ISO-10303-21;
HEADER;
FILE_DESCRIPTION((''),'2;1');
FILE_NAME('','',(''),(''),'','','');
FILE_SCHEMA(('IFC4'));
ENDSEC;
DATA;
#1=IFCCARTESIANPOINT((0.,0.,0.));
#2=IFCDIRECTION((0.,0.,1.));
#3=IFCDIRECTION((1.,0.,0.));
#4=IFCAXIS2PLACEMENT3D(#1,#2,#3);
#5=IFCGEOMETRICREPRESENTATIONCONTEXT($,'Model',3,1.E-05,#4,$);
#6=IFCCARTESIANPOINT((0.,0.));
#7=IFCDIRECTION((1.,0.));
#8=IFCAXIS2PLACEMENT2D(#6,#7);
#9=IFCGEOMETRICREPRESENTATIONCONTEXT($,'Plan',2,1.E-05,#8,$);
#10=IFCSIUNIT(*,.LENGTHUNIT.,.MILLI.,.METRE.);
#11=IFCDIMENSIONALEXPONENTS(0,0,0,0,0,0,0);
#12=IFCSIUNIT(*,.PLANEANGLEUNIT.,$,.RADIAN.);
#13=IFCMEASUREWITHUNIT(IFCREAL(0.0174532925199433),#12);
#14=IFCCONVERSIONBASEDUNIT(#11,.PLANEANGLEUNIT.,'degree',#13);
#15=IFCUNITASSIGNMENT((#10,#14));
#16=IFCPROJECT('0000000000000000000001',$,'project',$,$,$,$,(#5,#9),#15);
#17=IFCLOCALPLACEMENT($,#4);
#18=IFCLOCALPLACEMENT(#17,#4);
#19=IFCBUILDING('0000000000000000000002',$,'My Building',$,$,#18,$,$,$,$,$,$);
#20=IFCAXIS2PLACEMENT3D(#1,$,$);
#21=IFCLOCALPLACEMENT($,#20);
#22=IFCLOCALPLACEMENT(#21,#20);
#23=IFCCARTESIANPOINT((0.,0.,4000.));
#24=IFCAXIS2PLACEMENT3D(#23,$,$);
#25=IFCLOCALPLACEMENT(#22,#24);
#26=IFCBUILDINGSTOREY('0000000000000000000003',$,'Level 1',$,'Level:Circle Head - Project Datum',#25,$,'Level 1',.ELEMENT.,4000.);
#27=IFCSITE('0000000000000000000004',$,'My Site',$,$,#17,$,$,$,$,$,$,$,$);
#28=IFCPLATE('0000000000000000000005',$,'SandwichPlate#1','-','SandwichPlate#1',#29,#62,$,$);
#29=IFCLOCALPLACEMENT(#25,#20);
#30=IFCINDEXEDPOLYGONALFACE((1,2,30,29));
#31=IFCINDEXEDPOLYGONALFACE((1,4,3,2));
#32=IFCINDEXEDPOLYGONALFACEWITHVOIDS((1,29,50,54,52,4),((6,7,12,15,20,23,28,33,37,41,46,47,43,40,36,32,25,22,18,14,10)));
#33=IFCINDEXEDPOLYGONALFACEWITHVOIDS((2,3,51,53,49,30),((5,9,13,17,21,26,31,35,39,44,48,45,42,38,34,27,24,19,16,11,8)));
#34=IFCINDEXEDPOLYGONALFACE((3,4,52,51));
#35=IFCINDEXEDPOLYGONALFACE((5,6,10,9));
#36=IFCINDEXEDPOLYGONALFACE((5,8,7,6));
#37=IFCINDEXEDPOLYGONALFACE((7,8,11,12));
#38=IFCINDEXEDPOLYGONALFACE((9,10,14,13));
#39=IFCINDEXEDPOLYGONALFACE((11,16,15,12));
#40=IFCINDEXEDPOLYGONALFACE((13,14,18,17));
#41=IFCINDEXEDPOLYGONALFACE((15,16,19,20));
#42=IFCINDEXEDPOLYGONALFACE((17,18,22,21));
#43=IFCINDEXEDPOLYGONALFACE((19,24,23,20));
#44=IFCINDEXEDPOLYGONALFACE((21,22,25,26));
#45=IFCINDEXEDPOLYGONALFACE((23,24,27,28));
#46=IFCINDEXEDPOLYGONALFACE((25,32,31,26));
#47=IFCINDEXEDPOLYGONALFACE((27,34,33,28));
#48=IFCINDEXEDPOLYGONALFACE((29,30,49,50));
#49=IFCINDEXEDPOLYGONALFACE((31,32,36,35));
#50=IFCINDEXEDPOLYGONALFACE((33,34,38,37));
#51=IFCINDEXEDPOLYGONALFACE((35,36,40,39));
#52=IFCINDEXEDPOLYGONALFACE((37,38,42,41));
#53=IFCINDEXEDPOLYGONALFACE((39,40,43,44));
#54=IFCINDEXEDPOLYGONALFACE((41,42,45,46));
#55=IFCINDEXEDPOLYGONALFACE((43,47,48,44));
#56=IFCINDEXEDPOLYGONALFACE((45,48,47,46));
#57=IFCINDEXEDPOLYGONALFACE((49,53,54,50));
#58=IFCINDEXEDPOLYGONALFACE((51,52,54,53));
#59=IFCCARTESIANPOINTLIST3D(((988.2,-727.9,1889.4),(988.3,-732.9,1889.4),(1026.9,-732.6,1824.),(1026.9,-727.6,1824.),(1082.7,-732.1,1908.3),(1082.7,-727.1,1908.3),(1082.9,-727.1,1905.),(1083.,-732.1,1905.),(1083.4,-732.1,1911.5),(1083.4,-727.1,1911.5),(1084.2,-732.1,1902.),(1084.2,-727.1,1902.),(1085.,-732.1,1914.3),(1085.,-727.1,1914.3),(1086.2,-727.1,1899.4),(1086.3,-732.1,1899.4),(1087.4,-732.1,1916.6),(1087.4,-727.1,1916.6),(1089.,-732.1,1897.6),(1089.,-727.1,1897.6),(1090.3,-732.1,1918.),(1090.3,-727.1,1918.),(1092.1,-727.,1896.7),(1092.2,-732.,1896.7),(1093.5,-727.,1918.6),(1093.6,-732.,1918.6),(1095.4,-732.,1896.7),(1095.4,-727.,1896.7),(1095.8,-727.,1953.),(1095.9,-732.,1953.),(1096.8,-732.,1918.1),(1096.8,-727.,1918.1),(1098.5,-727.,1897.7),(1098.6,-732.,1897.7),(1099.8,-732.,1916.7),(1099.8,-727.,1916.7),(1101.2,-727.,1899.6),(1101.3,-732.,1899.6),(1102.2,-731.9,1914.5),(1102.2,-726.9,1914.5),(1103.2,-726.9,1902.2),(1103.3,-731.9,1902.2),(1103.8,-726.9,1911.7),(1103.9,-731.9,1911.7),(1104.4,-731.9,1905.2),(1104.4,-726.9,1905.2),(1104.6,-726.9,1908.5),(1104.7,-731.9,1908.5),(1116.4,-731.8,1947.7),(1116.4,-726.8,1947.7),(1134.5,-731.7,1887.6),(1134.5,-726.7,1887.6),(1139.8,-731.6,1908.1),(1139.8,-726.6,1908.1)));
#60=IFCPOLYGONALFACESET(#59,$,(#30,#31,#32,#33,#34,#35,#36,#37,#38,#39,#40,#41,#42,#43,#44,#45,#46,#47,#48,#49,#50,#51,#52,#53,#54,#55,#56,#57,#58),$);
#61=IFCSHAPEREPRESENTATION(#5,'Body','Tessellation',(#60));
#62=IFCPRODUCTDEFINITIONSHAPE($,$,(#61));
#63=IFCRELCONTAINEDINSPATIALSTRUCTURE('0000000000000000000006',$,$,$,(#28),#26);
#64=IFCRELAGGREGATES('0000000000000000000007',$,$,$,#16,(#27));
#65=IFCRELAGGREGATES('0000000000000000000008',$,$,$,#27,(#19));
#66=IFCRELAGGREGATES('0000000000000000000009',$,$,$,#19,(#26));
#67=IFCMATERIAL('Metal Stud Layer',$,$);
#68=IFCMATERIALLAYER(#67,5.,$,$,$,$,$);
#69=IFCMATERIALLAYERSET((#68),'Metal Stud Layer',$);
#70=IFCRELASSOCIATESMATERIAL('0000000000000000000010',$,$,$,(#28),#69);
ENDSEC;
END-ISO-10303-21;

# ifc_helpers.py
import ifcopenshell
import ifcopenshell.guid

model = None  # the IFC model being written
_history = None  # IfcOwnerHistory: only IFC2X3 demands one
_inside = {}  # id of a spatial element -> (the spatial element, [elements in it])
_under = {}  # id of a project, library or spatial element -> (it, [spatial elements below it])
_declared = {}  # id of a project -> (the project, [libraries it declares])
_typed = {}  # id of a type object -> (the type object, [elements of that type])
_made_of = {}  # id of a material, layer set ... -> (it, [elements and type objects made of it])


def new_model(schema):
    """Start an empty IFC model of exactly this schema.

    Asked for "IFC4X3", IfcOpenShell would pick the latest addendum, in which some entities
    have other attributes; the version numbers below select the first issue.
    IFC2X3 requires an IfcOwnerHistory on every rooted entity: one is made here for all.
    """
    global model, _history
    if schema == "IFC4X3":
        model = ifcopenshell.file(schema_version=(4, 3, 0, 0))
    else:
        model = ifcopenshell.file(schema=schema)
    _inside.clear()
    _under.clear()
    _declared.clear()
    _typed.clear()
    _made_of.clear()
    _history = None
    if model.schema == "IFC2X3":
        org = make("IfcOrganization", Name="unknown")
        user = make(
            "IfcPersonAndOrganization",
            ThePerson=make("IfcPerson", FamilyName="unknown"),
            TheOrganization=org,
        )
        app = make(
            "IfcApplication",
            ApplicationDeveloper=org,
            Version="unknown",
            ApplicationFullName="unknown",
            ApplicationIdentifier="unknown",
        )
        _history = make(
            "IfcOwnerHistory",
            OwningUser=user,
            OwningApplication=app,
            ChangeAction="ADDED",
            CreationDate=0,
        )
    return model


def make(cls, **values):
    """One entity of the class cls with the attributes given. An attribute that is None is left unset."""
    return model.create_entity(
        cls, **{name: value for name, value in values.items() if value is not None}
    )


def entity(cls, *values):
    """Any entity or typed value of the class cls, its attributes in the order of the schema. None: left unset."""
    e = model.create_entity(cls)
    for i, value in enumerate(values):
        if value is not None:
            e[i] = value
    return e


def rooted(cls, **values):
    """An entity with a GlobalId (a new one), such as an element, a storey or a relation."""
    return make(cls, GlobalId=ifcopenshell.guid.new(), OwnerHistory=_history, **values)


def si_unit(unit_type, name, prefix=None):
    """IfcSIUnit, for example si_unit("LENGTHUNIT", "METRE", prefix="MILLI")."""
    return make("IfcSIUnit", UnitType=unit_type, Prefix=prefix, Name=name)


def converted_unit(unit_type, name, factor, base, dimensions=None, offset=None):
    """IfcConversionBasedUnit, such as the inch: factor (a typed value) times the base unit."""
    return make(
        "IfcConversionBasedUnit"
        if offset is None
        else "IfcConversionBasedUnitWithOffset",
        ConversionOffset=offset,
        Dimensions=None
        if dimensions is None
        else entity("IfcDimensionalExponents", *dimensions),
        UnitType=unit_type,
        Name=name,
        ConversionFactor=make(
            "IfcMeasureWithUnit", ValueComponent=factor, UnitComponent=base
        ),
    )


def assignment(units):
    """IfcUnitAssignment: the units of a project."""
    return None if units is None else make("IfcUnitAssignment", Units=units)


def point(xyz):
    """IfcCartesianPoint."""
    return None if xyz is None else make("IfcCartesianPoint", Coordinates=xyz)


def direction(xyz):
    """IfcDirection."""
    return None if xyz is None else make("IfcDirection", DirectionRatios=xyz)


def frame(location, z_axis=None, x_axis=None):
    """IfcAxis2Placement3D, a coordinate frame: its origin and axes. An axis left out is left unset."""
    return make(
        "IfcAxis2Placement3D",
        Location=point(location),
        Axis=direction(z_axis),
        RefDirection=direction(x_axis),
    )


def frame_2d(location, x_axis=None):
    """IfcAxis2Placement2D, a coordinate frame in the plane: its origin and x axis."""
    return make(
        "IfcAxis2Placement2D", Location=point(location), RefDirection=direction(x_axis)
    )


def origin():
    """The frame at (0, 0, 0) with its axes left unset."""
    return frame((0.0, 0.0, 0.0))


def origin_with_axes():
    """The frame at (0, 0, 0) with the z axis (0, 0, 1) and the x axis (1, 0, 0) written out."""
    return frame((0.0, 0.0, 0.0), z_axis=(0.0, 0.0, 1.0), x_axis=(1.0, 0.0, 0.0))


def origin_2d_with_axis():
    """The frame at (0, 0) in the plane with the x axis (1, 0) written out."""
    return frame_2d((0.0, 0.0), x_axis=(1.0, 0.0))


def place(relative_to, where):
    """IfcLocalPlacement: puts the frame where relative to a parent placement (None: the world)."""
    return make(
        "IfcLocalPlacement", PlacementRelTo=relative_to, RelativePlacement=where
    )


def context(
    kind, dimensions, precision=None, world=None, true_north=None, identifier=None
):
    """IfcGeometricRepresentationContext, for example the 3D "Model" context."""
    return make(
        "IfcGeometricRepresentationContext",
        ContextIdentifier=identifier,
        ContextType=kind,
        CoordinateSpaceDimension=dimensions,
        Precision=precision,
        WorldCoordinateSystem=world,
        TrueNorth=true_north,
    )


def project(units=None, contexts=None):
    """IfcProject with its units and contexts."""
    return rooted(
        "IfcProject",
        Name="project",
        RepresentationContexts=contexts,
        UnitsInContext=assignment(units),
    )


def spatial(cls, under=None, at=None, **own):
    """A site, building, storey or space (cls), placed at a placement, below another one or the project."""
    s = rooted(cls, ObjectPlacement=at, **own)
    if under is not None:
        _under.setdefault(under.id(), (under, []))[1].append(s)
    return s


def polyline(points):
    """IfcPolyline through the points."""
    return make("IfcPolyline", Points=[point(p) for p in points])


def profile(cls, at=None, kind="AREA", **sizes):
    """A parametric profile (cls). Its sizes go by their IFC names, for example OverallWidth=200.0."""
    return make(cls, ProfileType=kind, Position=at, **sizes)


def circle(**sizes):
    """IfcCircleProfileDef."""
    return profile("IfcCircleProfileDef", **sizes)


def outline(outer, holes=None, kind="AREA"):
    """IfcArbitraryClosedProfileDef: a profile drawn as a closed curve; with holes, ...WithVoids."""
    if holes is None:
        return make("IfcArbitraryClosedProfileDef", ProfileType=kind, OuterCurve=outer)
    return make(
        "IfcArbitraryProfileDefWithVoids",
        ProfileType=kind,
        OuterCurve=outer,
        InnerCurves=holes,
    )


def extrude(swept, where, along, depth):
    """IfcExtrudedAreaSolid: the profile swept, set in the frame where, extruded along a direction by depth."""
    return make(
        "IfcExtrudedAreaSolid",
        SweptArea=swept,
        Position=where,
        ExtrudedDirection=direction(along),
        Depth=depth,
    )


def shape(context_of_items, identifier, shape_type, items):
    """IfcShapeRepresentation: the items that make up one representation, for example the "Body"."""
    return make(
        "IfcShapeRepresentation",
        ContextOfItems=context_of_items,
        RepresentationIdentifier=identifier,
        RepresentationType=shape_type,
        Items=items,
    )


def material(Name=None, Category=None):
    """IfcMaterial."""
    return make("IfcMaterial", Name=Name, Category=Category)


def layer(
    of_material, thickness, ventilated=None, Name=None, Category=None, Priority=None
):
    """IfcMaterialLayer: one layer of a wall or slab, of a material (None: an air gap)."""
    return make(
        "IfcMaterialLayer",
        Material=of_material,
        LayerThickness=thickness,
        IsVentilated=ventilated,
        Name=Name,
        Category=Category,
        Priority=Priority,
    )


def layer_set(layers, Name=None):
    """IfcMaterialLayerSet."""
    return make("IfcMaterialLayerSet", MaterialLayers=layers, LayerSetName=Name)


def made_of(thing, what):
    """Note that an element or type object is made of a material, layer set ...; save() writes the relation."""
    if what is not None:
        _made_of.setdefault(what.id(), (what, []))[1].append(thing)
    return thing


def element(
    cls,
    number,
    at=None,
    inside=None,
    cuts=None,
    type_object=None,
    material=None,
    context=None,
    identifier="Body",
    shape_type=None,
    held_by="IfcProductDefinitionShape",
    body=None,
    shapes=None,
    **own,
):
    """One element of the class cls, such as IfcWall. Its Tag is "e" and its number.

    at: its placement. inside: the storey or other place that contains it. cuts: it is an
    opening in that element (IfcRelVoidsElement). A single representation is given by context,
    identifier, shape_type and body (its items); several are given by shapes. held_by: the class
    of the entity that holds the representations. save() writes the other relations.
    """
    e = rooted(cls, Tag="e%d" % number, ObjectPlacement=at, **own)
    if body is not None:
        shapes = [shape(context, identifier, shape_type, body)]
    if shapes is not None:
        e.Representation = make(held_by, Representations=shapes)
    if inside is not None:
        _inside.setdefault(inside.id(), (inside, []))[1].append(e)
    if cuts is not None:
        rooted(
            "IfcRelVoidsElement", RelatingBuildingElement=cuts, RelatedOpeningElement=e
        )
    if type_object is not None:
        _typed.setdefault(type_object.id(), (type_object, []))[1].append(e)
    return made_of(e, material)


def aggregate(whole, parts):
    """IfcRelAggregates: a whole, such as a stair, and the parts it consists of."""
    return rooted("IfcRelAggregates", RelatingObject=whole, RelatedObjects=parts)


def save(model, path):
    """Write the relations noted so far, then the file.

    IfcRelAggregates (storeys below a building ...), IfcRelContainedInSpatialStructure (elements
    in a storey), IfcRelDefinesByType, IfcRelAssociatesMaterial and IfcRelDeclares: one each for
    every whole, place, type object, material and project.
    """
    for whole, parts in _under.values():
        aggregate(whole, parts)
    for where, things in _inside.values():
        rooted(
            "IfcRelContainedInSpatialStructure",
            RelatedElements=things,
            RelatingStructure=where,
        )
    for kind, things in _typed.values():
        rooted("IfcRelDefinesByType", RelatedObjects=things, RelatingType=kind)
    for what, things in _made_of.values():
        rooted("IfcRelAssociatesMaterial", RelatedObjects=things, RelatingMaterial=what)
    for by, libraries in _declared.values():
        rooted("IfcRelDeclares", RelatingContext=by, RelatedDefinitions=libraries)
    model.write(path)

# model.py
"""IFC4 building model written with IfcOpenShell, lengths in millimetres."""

from ifc_helpers import new_model, entity, si_unit, converted_unit, frame, origin, origin_with_axes, origin_2d_with_axis, place, context, project, spatial, polyline, circle, outline, extrude, material, layer, layer_set, element, save


model = new_model("IFC4")

# Units and contexts
model_context = context("Model", 3, precision=1e-05, world=origin_with_axes())
plan_context = context("Plan", 2, precision=1e-05, world=origin_2d_with_axis())
ifc_project = project(units=[si_unit("LENGTHUNIT", "METRE", prefix="MILLI"), converted_unit("PLANEANGLEUNIT", "degree", entity("IfcReal", 0.0174532925199433), si_unit("PLANEANGLEUNIT", "RADIAN"), dimensions=[0, 0, 0, 0, 0, 0, 0])], contexts=[model_context, plan_context])

# Site, building, storey
site_placement = place(None, origin_with_axes())
site = spatial("IfcSite", under=ifc_project, at=site_placement, Name="My Site")
building_placement = place(site_placement, origin_with_axes())
building = spatial("IfcBuilding", under=site, at=building_placement, Name="My Building")
placement_1 = place(None, origin())
placement_2 = place(placement_1, origin())
storey_placement = place(placement_2, frame((0.0, 0.0, 4000.0)))
storey = spatial("IfcBuildingStorey", under=building, at=storey_placement, Name="Level 1", ObjectType="Level:Circle Head - Project Datum", LongName="Level 1", CompositionType="ELEMENT", Elevation=4000.0)

# Shared definitions
ifc_material_1 = material(Name="Metal Stud Layer")
ifc_layer_1 = layer(ifc_material_1, 5.0)
ifc_layer_set_1 = layer_set([ifc_layer_1], Name="Metal Stud Layer")

# Plate, opening
plate_1_placement = place(storey_placement, frame((1108.8, -731.9, 1960.6), z_axis=(-0.008532, 0.999964, 0.0), x_axis=(0.50884, 0.004342, -0.86085)))
plate_1 = element("IfcPlate", 1, at=plate_1_placement, inside=storey, material=ifc_layer_set_1, Name="SandwichPlate#1", Description="-", ObjectType="SandwichPlate#1", context=model_context, shape_type="SweptSolid", body=[
    extrude(outline(polyline([(15.0, 0.0), (61.0, 0.0), (76.0, 15.0), (76.0, 140.0), (0.0, 140.0), (0.0, 15.0), (15.0, 0.0)])), origin_with_axes(), (0.0, 0.0, 1.0), 5.0),
])
opening_1_placement = place(plate_1_placement, frame((38.0, 40.0, -0.5), z_axis=(0.0, 0.0, 1.0), x_axis=(0.0, 1.0, 0.0)))
element("IfcOpeningElement", 2, at=opening_1_placement, cuts=plate_1, ObjectType="Opening", context=model_context, shape_type="SweptSolid", body=[
    extrude(circle(Radius=11.0, at=origin_2d_with_axis()), origin(), (0.0, 0.0, 1.0), 6.0),
])

save(model, "model.ifc")
